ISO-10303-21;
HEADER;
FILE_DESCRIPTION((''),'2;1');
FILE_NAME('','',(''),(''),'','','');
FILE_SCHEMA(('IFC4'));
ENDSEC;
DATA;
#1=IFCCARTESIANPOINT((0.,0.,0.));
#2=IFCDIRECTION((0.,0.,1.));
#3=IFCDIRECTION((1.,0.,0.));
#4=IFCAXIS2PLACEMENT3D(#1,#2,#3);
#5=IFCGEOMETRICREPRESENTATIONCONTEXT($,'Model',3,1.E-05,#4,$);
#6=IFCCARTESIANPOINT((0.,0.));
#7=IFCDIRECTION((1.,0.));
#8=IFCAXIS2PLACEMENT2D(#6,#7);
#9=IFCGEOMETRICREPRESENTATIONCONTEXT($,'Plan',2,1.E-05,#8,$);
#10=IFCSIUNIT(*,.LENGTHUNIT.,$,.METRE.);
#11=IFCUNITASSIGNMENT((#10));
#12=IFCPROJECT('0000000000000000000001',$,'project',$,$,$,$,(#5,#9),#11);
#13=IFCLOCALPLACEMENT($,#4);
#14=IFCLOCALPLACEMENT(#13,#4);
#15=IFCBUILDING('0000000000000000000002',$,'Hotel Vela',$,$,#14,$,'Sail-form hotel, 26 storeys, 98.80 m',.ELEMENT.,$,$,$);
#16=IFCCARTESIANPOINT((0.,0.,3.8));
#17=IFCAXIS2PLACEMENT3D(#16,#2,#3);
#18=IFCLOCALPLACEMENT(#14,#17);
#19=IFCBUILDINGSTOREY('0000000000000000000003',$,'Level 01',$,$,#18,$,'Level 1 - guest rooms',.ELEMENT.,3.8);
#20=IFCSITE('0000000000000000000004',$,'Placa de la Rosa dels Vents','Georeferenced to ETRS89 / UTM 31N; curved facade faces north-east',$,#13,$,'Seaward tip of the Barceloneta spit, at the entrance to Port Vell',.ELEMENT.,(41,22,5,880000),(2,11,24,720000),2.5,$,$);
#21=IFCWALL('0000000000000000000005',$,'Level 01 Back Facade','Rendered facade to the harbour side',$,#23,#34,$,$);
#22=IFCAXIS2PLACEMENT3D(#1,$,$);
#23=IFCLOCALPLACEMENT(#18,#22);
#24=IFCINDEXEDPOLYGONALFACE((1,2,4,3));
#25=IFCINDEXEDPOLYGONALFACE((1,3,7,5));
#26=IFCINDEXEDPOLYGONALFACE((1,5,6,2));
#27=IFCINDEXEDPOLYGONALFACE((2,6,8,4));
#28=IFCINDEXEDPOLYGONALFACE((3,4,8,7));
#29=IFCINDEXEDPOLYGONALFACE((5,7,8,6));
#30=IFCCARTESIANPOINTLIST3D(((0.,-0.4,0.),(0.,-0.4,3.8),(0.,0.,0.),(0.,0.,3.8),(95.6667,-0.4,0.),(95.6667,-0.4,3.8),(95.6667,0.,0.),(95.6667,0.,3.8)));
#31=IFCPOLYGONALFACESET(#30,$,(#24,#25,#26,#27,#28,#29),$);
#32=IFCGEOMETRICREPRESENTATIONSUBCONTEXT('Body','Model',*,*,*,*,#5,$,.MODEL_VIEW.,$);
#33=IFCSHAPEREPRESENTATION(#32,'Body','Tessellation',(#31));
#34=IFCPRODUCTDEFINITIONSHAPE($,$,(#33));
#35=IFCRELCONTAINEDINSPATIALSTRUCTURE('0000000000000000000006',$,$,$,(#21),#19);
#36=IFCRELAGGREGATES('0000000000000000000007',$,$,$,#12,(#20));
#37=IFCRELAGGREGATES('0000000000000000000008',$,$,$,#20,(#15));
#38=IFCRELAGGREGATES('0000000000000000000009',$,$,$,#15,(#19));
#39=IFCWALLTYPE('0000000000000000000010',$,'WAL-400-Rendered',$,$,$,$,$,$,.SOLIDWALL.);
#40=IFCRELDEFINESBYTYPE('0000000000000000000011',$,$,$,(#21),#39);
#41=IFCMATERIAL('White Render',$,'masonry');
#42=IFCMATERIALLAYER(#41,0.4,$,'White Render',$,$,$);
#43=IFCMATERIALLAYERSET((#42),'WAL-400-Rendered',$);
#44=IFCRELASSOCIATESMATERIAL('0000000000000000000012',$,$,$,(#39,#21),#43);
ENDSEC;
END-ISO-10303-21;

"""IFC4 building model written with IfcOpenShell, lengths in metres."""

from ifc_helpers import new_model, si_unit, frame, origin_with_axes, origin_2d_with_axis, place, context, subcontext, project, spatial, line, indexed_curve, outline, extrude, material, layer, layer_set, layer_usage, type_object, element, save


model = new_model("IFC4")

# Units and contexts
model_context = context("Model", 3, precision=1e-05, world=origin_with_axes())
plan_context = context("Plan", 2, precision=1e-05, world=origin_2d_with_axis())
body_context = subcontext(model_context, "Body", "Model", "MODEL_VIEW")
ifc_project = project(units=[si_unit("LENGTHUNIT", "METRE")], contexts=[model_context, plan_context])

# Site, building, storey
site_placement = place(None, origin_with_axes())
site = spatial("IfcSite", under=ifc_project, at=site_placement, Name="Placa de la Rosa dels Vents", Description="Georeferenced to ETRS89 / UTM 31N; curved facade faces north-east", LongName="Seaward tip of the Barceloneta spit, at the entrance to Port Vell", CompositionType="ELEMENT", RefLatitude=(41, 22, 5, 880000), RefLongitude=(2, 11, 24, 720000), RefElevation=2.5)
building_placement = place(site_placement, origin_with_axes())
building = spatial("IfcBuilding", under=site, at=building_placement, Name="Hotel Vela", LongName="Sail-form hotel, 26 storeys, 98.80 m", CompositionType="ELEMENT")
storey_placement = place(building_placement, frame((0.0, 0.0, 3.8), z_axis=(0.0, 0.0, 1.0), x_axis=(1.0, 0.0, 0.0)))
storey = spatial("IfcBuildingStorey", under=building, at=storey_placement, Name="Level 01", LongName="Level 1 - guest rooms", CompositionType="ELEMENT", Elevation=3.8)

# Wall
ifc_material_1 = material(Name="White Render", Category="masonry")
ifc_layer_1 = layer(ifc_material_1, 0.4, Name="White Render")
ifc_layer_set_1 = layer_set([ifc_layer_1], Name="WAL-400-Rendered")
ifc_layer_usage_1 = layer_usage(ifc_layer_set_1, "AXIS2", "POSITIVE", 0.0)
wall_type = type_object("IfcWallType", Name="WAL-400-Rendered", PredefinedType="SOLIDWALL", material=ifc_layer_set_1)
wall_placement = place(storey_placement, frame((0.0, -0.4, 0.0), z_axis=(0.0, 0.0, 1.0), x_axis=(1.0, 0.0, 0.0)))
element("IfcWall", 1, at=wall_placement, inside=storey, type_object=wall_type, material=ifc_layer_usage_1, Name="Level 01 Back Facade", Description="Rendered facade to the harbour side", context=body_context, shape_type="SweptSolid", body=[
    extrude(outline(indexed_curve([(0.0, 0.0), (95.6667, 0.0), (95.6667, 0.4), (0.0, 0.4)], segments=[line(1, 2, 3, 4, 1)])), origin_with_axes(), (0.0, 0.0, 1.0), 3.8),
])

save(model, "model.ifc")
